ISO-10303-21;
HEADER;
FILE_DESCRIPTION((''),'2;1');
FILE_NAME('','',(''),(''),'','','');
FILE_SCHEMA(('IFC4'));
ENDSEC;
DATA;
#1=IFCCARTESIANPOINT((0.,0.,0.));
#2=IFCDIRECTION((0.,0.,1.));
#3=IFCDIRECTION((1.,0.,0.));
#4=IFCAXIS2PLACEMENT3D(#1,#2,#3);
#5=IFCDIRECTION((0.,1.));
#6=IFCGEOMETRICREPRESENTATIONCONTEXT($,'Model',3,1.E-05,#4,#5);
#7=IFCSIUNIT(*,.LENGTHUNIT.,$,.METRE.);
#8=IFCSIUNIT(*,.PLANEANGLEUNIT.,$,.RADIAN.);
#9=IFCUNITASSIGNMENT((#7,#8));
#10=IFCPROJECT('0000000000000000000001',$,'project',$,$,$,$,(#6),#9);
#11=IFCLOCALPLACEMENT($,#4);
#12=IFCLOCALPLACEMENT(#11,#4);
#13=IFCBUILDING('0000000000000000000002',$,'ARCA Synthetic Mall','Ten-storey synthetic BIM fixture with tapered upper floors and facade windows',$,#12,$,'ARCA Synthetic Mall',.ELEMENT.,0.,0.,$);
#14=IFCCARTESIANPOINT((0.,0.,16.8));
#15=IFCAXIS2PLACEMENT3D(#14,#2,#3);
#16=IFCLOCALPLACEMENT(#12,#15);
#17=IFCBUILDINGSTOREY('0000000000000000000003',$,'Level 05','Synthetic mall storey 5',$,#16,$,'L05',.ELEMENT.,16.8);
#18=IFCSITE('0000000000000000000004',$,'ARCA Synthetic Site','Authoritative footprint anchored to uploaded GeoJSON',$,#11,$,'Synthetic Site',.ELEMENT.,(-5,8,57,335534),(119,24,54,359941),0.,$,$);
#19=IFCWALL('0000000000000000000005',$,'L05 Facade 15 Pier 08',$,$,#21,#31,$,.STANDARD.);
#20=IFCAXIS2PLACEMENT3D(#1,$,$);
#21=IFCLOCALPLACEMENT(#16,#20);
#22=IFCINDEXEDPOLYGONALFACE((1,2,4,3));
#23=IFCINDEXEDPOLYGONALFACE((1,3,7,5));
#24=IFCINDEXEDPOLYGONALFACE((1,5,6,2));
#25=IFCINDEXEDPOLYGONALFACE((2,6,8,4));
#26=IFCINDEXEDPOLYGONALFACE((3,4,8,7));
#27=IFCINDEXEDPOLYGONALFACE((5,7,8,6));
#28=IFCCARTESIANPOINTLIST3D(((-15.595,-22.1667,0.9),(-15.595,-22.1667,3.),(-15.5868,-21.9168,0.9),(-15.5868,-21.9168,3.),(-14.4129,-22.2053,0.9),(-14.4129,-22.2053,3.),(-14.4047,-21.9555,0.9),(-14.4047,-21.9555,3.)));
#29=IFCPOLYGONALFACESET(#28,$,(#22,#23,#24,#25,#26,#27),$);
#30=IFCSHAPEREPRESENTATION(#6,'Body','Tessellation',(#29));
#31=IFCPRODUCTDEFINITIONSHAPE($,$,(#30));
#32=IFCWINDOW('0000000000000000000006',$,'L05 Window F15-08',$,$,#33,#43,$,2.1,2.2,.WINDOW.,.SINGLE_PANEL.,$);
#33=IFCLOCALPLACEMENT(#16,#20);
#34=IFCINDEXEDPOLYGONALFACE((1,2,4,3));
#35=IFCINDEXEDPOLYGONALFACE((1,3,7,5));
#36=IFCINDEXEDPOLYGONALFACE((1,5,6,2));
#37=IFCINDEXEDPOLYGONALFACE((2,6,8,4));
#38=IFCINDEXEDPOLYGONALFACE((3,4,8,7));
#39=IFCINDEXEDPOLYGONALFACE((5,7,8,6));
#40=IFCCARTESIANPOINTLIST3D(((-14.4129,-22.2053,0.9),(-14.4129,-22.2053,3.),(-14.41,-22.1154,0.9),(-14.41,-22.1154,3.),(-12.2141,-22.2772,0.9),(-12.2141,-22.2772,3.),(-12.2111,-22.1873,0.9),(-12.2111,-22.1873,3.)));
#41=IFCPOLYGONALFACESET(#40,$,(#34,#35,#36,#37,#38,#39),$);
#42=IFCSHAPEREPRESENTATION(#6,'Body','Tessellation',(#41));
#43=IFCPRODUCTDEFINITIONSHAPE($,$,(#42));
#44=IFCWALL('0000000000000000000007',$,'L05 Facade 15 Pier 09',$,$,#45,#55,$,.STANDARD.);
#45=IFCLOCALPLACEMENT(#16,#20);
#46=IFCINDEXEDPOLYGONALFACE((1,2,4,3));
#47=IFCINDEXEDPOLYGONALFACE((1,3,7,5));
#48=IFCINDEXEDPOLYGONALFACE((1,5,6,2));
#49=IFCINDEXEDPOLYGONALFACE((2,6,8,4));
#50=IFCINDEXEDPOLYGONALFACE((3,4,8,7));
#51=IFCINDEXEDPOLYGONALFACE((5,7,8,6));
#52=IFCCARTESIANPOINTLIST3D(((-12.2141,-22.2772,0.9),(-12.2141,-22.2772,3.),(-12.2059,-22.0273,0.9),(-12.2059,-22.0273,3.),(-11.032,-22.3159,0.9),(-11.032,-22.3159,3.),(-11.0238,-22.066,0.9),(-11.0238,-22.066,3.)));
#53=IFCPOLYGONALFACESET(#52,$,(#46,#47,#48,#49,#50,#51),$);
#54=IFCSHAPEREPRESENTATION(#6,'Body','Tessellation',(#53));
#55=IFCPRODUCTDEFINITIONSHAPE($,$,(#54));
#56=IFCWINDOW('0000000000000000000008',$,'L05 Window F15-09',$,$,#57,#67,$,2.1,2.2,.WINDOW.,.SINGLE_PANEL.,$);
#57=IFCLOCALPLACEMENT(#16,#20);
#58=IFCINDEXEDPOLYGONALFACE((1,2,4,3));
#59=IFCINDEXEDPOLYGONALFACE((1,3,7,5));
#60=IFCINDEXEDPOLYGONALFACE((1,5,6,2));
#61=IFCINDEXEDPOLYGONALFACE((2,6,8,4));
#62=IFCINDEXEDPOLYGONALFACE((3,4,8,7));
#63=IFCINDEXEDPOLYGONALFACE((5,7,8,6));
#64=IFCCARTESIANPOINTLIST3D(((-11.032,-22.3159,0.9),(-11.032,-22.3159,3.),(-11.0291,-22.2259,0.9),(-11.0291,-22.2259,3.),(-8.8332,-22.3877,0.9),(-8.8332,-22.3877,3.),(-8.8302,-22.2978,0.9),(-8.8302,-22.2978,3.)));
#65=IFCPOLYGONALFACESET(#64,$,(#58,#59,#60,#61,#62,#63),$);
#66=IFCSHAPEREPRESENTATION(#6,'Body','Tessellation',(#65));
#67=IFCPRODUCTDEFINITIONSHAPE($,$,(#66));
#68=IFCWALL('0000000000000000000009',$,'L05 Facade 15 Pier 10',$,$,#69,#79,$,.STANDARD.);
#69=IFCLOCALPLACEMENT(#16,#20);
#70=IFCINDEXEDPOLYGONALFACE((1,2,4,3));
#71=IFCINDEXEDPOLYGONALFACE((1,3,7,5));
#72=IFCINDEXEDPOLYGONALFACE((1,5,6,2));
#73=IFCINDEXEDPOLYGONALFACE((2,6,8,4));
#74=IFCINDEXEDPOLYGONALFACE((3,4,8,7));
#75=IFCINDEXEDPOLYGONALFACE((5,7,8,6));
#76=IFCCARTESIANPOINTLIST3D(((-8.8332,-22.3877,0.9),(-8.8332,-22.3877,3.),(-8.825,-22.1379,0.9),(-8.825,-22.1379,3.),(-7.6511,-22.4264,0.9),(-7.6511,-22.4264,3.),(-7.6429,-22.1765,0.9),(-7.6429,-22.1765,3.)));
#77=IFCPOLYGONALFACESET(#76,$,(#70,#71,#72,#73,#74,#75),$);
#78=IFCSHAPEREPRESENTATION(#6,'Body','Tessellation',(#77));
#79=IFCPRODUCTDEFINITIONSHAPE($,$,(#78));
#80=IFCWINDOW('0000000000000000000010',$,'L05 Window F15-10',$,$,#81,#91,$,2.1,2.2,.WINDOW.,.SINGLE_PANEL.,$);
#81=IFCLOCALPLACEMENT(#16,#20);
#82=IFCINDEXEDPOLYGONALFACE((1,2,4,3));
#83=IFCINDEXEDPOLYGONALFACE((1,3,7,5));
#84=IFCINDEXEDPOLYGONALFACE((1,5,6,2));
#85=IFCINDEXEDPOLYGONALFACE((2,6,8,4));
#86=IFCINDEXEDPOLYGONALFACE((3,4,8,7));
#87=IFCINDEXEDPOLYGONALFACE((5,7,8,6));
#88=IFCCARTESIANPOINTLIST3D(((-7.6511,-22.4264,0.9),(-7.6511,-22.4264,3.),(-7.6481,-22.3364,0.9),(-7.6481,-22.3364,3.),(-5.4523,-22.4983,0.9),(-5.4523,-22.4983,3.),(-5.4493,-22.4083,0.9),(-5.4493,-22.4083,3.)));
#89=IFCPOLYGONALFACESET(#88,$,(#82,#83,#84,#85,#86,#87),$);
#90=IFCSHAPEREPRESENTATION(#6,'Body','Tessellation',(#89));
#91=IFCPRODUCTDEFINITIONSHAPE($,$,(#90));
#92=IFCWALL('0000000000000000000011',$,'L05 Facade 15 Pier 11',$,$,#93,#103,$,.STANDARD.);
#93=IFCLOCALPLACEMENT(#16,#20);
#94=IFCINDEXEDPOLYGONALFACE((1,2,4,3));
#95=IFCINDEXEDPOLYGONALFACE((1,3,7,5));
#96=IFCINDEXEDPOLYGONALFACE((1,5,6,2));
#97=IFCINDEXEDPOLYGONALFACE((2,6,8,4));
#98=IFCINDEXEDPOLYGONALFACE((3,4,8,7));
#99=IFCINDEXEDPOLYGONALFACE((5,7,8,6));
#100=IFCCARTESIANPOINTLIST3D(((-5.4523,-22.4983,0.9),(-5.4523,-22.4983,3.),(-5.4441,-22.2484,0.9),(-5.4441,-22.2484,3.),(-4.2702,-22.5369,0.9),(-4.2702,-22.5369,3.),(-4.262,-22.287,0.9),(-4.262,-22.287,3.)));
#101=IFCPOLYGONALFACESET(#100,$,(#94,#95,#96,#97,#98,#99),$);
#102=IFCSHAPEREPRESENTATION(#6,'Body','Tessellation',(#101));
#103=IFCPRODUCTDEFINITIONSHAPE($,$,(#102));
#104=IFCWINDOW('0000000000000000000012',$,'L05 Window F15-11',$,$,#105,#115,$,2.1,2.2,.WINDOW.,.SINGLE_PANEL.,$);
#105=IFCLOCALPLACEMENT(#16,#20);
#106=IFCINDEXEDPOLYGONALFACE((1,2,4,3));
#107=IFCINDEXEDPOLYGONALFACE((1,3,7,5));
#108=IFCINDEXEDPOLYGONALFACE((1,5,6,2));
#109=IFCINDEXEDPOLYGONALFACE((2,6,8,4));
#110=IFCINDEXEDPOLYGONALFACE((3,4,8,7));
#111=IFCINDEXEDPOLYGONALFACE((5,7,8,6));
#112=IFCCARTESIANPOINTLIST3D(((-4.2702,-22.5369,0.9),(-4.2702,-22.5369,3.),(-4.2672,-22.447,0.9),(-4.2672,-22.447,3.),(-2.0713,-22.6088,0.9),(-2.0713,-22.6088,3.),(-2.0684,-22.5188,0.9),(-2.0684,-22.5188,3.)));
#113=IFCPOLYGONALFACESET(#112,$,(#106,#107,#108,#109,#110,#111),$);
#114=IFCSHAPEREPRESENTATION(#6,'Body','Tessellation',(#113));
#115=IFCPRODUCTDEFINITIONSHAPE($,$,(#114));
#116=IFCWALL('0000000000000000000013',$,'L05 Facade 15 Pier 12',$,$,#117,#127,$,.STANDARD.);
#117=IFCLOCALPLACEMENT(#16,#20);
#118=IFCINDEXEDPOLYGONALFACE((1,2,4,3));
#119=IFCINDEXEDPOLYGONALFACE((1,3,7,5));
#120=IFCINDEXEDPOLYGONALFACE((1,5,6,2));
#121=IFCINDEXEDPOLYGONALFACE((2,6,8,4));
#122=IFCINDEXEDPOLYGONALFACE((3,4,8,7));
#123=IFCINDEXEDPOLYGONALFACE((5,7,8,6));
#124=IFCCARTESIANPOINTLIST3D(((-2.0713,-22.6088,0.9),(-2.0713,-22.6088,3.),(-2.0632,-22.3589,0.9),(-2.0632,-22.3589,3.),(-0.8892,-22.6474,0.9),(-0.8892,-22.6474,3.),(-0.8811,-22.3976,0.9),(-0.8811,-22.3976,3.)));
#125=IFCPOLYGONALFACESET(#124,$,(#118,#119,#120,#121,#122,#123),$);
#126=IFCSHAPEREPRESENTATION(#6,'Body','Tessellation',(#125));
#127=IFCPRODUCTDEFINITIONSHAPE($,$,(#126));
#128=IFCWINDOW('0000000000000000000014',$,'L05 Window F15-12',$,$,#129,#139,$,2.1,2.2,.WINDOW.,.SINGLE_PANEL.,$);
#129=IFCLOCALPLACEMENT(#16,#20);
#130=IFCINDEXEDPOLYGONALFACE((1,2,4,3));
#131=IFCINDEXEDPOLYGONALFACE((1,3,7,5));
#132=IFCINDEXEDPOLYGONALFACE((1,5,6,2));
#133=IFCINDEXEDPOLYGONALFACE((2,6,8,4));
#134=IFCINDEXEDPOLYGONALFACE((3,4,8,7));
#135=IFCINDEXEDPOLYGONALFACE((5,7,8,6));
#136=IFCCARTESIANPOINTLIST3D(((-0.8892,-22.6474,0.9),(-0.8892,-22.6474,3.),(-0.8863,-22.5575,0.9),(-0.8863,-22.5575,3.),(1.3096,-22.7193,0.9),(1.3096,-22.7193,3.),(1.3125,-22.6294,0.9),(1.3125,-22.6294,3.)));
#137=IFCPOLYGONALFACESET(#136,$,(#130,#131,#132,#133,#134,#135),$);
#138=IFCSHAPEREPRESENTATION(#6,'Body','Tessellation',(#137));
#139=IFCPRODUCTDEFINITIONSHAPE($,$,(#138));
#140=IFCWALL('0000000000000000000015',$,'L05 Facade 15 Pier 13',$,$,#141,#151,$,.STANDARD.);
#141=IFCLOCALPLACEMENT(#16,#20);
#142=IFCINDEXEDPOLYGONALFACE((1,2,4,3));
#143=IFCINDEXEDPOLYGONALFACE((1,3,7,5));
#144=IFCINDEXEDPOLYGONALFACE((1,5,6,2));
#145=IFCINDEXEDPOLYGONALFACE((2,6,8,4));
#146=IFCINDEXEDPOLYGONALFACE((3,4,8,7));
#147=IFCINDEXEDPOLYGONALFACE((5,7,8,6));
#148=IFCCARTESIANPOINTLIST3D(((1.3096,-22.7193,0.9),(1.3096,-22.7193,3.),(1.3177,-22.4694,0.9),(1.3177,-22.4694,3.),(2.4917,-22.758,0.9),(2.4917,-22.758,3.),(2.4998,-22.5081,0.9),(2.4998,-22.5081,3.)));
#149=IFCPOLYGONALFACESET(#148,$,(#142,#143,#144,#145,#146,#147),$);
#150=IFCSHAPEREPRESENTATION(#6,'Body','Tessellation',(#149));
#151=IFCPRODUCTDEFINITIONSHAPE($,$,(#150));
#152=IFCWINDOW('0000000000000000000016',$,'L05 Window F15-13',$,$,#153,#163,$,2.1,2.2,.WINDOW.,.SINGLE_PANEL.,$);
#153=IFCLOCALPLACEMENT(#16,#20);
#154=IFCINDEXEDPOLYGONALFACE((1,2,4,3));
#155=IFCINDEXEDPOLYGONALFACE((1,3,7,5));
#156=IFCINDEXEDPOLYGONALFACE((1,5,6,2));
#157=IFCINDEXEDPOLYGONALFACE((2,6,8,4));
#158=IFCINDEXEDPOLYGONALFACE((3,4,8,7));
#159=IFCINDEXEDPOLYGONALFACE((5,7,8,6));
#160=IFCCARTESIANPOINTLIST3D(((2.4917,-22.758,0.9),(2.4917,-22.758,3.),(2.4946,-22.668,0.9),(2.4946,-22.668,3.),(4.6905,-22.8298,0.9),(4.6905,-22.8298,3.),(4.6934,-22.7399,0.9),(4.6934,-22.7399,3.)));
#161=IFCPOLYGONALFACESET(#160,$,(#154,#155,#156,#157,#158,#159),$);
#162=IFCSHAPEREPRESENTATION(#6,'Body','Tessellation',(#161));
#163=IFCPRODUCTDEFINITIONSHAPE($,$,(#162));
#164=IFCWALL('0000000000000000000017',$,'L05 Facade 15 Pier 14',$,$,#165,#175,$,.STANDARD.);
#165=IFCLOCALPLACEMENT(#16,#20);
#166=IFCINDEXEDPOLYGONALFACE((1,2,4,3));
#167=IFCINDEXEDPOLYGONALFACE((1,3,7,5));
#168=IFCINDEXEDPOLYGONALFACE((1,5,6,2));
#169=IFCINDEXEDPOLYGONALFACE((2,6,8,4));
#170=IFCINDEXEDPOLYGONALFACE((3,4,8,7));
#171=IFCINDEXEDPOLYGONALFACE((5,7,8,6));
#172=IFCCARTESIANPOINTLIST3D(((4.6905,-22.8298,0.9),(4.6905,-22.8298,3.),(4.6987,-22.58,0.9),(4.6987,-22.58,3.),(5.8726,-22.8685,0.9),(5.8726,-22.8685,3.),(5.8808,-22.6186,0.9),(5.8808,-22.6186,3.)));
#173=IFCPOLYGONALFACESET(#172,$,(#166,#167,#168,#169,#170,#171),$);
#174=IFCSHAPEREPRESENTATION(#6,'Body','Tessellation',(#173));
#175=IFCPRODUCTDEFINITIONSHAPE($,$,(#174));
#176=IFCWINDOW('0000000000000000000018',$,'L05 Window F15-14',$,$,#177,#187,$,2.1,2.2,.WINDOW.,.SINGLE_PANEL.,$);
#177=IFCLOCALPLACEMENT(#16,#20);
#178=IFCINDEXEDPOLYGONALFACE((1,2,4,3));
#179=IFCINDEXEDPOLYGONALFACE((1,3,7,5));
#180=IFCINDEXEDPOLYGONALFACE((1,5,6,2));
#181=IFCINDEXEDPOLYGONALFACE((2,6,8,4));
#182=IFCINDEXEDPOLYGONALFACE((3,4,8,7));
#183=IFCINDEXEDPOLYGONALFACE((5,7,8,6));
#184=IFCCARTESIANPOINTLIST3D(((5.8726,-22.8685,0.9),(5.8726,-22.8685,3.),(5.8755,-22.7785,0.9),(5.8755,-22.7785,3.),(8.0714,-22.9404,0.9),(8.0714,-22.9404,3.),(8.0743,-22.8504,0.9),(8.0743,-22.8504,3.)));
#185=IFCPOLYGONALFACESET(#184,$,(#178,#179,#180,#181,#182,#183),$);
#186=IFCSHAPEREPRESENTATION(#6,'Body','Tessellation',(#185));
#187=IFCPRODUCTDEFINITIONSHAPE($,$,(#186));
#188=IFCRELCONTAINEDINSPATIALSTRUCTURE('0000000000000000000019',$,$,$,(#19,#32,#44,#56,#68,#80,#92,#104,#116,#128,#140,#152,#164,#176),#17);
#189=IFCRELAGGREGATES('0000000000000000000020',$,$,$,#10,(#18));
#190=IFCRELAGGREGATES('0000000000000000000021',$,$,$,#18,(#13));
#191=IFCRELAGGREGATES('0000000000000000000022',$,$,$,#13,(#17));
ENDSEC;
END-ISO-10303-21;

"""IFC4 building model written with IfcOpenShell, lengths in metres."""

from ifc_helpers import new_model, si_unit, direction, frame, origin_with_axes, place, context, project, spatial, polyline, outline, extrude, element, save


model = new_model("IFC4")

# Units and contexts
model_context = context("Model", 3, precision=1e-05, world=origin_with_axes(), true_north=direction((0.0, 1.0)))
ifc_project = project(units=[si_unit("LENGTHUNIT", "METRE"), si_unit("PLANEANGLEUNIT", "RADIAN")], contexts=[model_context])

# Site, building, storey
site_placement = place(None, origin_with_axes())
site = spatial("IfcSite", under=ifc_project, at=site_placement, Name="ARCA Synthetic Site", Description="Authoritative footprint anchored to uploaded GeoJSON", LongName="Synthetic Site", CompositionType="ELEMENT", RefLatitude=(-5, 8, 57, 335534), RefLongitude=(119, 24, 54, 359941), RefElevation=0.0)
building_placement = place(site_placement, origin_with_axes())
building = spatial("IfcBuilding", under=site, at=building_placement, Name="ARCA Synthetic Mall", Description="Ten-storey synthetic BIM fixture with tapered upper floors and facade windows", LongName="ARCA Synthetic Mall", CompositionType="ELEMENT", ElevationOfRefHeight=0.0, ElevationOfTerrain=0.0)
storey_placement = place(building_placement, frame((0.0, 0.0, 16.8), z_axis=(0.0, 0.0, 1.0), x_axis=(1.0, 0.0, 0.0)))
storey = spatial("IfcBuildingStorey", under=building, at=storey_placement, Name="Level 05", Description="Synthetic mall storey 5", LongName="L05", CompositionType="ELEMENT", Elevation=16.8)

# Wall
wall_1_placement = place(storey_placement, frame((0.0, 0.0, 0.9), z_axis=(0.0, 0.0, 1.0), x_axis=(1.0, 0.0, 0.0)))
element("IfcWall", 1, at=wall_1_placement, inside=storey, Name="L05 Facade 15 Pier 08", PredefinedType="STANDARD", context=model_context, shape_type="SweptSolid", body=[
    extrude(outline(polyline([(-15.595, -22.1667), (-14.4129, -22.2053), (-14.4047, -21.9555), (-15.5868, -21.9168), (-15.595, -22.1667)])), origin_with_axes(), (0.0, 0.0, 1.0), 2.1),
])

# Window
window_1_placement = place(storey_placement, frame((0.0, 0.0, 0.9), z_axis=(0.0, 0.0, 1.0), x_axis=(1.0, 0.0, 0.0)))
element("IfcWindow", 2, at=window_1_placement, inside=storey, Name="L05 Window F15-08", OverallHeight=2.1, OverallWidth=2.2, PartitioningType="SINGLE_PANEL", PredefinedType="WINDOW", context=model_context, shape_type="SweptSolid", body=[
    extrude(outline(polyline([(-14.4129, -22.2053), (-12.2141, -22.2772), (-12.2111, -22.1873), (-14.41, -22.1154), (-14.4129, -22.2053)])), origin_with_axes(), (0.0, 0.0, 1.0), 2.1),
])

# Wall
wall_2_placement = place(storey_placement, frame((0.0, 0.0, 0.9), z_axis=(0.0, 0.0, 1.0), x_axis=(1.0, 0.0, 0.0)))
element("IfcWall", 3, at=wall_2_placement, inside=storey, Name="L05 Facade 15 Pier 09", PredefinedType="STANDARD", context=model_context, shape_type="SweptSolid", body=[
    extrude(outline(polyline([(-12.2141, -22.2772), (-11.032, -22.3159), (-11.0238, -22.066), (-12.2059, -22.0273), (-12.2141, -22.2772)])), origin_with_axes(), (0.0, 0.0, 1.0), 2.1),
])

# Window
window_2_placement = place(storey_placement, frame((0.0, 0.0, 0.9), z_axis=(0.0, 0.0, 1.0), x_axis=(1.0, 0.0, 0.0)))
element("IfcWindow", 4, at=window_2_placement, inside=storey, Name="L05 Window F15-09", OverallHeight=2.1, OverallWidth=2.2, PartitioningType="SINGLE_PANEL", PredefinedType="WINDOW", context=model_context, shape_type="SweptSolid", body=[
    extrude(outline(polyline([(-11.032, -22.3159), (-8.8332, -22.3877), (-8.8302, -22.2978), (-11.0291, -22.2259), (-11.032, -22.3159)])), origin_with_axes(), (0.0, 0.0, 1.0), 2.1),
])

# Wall
wall_3_placement = place(storey_placement, frame((0.0, 0.0, 0.9), z_axis=(0.0, 0.0, 1.0), x_axis=(1.0, 0.0, 0.0)))
element("IfcWall", 5, at=wall_3_placement, inside=storey, Name="L05 Facade 15 Pier 10", PredefinedType="STANDARD", context=model_context, shape_type="SweptSolid", body=[
    extrude(outline(polyline([(-8.8332, -22.3877), (-7.6511, -22.4264), (-7.6429, -22.1765), (-8.825, -22.1379), (-8.8332, -22.3877)])), origin_with_axes(), (0.0, 0.0, 1.0), 2.1),
])

# Window
window_3_placement = place(storey_placement, frame((0.0, 0.0, 0.9), z_axis=(0.0, 0.0, 1.0), x_axis=(1.0, 0.0, 0.0)))
element("IfcWindow", 6, at=window_3_placement, inside=storey, Name="L05 Window F15-10", OverallHeight=2.1, OverallWidth=2.2, PartitioningType="SINGLE_PANEL", PredefinedType="WINDOW", context=model_context, shape_type="SweptSolid", body=[
    extrude(outline(polyline([(-7.6511, -22.4264), (-5.4523, -22.4983), (-5.4493, -22.4083), (-7.6481, -22.3364), (-7.6511, -22.4264)])), origin_with_axes(), (0.0, 0.0, 1.0), 2.1),
])

# Wall
wall_4_placement = place(storey_placement, frame((0.0, 0.0, 0.9), z_axis=(0.0, 0.0, 1.0), x_axis=(1.0, 0.0, 0.0)))
element("IfcWall", 7, at=wall_4_placement, inside=storey, Name="L05 Facade 15 Pier 11", PredefinedType="STANDARD", context=model_context, shape_type="SweptSolid", body=[
    extrude(outline(polyline([(-5.4523, -22.4983), (-4.2702, -22.5369), (-4.262, -22.287), (-5.4441, -22.2484), (-5.4523, -22.4983)])), origin_with_axes(), (0.0, 0.0, 1.0), 2.1),
])

# Window
window_4_placement = place(storey_placement, frame((0.0, 0.0, 0.9), z_axis=(0.0, 0.0, 1.0), x_axis=(1.0, 0.0, 0.0)))
element("IfcWindow", 8, at=window_4_placement, inside=storey, Name="L05 Window F15-11", OverallHeight=2.1, OverallWidth=2.2, PartitioningType="SINGLE_PANEL", PredefinedType="WINDOW", context=model_context, shape_type="SweptSolid", body=[
    extrude(outline(polyline([(-4.2702, -22.5369), (-2.0713, -22.6088), (-2.0684, -22.5188), (-4.2672, -22.447), (-4.2702, -22.5369)])), origin_with_axes(), (0.0, 0.0, 1.0), 2.1),
])

# Wall
wall_5_placement = place(storey_placement, frame((0.0, 0.0, 0.9), z_axis=(0.0, 0.0, 1.0), x_axis=(1.0, 0.0, 0.0)))
element("IfcWall", 9, at=wall_5_placement, inside=storey, Name="L05 Facade 15 Pier 12", PredefinedType="STANDARD", context=model_context, shape_type="SweptSolid", body=[
    extrude(outline(polyline([(-2.0713, -22.6088), (-0.8892, -22.6474), (-0.8811, -22.3976), (-2.0632, -22.3589), (-2.0713, -22.6088)])), origin_with_axes(), (0.0, 0.0, 1.0), 2.1),
])

# Window
window_5_placement = place(storey_placement, frame((0.0, 0.0, 0.9), z_axis=(0.0, 0.0, 1.0), x_axis=(1.0, 0.0, 0.0)))
element("IfcWindow", 10, at=window_5_placement, inside=storey, Name="L05 Window F15-12", OverallHeight=2.1, OverallWidth=2.2, PartitioningType="SINGLE_PANEL", PredefinedType="WINDOW", context=model_context, shape_type="SweptSolid", body=[
    extrude(outline(polyline([(-0.8892, -22.6474), (1.3096, -22.7193), (1.3125, -22.6294), (-0.8863, -22.5575), (-0.8892, -22.6474)])), origin_with_axes(), (0.0, 0.0, 1.0), 2.1),
])

# Wall
wall_6_placement = place(storey_placement, frame((0.0, 0.0, 0.9), z_axis=(0.0, 0.0, 1.0), x_axis=(1.0, 0.0, 0.0)))
element("IfcWall", 11, at=wall_6_placement, inside=storey, Name="L05 Facade 15 Pier 13", PredefinedType="STANDARD", context=model_context, shape_type="SweptSolid", body=[
    extrude(outline(polyline([(1.3096, -22.7193), (2.4917, -22.758), (2.4998, -22.5081), (1.3177, -22.4694), (1.3096, -22.7193)])), origin_with_axes(), (0.0, 0.0, 1.0), 2.1),
])

# Window
window_6_placement = place(storey_placement, frame((0.0, 0.0, 0.9), z_axis=(0.0, 0.0, 1.0), x_axis=(1.0, 0.0, 0.0)))
element("IfcWindow", 12, at=window_6_placement, inside=storey, Name="L05 Window F15-13", OverallHeight=2.1, OverallWidth=2.2, PartitioningType="SINGLE_PANEL", PredefinedType="WINDOW", context=model_context, shape_type="SweptSolid", body=[
    extrude(outline(polyline([(2.4917, -22.758), (4.6905, -22.8298), (4.6934, -22.7399), (2.4946, -22.668), (2.4917, -22.758)])), origin_with_axes(), (0.0, 0.0, 1.0), 2.1),
])

# Wall
wall_7_placement = place(storey_placement, frame((0.0, 0.0, 0.9), z_axis=(0.0, 0.0, 1.0), x_axis=(1.0, 0.0, 0.0)))
element("IfcWall", 13, at=wall_7_placement, inside=storey, Name="L05 Facade 15 Pier 14", PredefinedType="STANDARD", context=model_context, shape_type="SweptSolid", body=[
    extrude(outline(polyline([(4.6905, -22.8298), (5.8726, -22.8685), (5.8808, -22.6186), (4.6987, -22.58), (4.6905, -22.8298)])), origin_with_axes(), (0.0, 0.0, 1.0), 2.1),
])

# Window
window_7_placement = place(storey_placement, frame((0.0, 0.0, 0.9), z_axis=(0.0, 0.0, 1.0), x_axis=(1.0, 0.0, 0.0)))
element("IfcWindow", 14, at=window_7_placement, inside=storey, Name="L05 Window F15-14", OverallHeight=2.1, OverallWidth=2.2, PartitioningType="SINGLE_PANEL", PredefinedType="WINDOW", context=model_context, shape_type="SweptSolid", body=[
    extrude(outline(polyline([(5.8726, -22.8685), (8.0714, -22.9404), (8.0743, -22.8504), (5.8755, -22.7785), (5.8726, -22.8685)])), origin_with_axes(), (0.0, 0.0, 1.0), 2.1),
])

save(model, "model.ifc")
